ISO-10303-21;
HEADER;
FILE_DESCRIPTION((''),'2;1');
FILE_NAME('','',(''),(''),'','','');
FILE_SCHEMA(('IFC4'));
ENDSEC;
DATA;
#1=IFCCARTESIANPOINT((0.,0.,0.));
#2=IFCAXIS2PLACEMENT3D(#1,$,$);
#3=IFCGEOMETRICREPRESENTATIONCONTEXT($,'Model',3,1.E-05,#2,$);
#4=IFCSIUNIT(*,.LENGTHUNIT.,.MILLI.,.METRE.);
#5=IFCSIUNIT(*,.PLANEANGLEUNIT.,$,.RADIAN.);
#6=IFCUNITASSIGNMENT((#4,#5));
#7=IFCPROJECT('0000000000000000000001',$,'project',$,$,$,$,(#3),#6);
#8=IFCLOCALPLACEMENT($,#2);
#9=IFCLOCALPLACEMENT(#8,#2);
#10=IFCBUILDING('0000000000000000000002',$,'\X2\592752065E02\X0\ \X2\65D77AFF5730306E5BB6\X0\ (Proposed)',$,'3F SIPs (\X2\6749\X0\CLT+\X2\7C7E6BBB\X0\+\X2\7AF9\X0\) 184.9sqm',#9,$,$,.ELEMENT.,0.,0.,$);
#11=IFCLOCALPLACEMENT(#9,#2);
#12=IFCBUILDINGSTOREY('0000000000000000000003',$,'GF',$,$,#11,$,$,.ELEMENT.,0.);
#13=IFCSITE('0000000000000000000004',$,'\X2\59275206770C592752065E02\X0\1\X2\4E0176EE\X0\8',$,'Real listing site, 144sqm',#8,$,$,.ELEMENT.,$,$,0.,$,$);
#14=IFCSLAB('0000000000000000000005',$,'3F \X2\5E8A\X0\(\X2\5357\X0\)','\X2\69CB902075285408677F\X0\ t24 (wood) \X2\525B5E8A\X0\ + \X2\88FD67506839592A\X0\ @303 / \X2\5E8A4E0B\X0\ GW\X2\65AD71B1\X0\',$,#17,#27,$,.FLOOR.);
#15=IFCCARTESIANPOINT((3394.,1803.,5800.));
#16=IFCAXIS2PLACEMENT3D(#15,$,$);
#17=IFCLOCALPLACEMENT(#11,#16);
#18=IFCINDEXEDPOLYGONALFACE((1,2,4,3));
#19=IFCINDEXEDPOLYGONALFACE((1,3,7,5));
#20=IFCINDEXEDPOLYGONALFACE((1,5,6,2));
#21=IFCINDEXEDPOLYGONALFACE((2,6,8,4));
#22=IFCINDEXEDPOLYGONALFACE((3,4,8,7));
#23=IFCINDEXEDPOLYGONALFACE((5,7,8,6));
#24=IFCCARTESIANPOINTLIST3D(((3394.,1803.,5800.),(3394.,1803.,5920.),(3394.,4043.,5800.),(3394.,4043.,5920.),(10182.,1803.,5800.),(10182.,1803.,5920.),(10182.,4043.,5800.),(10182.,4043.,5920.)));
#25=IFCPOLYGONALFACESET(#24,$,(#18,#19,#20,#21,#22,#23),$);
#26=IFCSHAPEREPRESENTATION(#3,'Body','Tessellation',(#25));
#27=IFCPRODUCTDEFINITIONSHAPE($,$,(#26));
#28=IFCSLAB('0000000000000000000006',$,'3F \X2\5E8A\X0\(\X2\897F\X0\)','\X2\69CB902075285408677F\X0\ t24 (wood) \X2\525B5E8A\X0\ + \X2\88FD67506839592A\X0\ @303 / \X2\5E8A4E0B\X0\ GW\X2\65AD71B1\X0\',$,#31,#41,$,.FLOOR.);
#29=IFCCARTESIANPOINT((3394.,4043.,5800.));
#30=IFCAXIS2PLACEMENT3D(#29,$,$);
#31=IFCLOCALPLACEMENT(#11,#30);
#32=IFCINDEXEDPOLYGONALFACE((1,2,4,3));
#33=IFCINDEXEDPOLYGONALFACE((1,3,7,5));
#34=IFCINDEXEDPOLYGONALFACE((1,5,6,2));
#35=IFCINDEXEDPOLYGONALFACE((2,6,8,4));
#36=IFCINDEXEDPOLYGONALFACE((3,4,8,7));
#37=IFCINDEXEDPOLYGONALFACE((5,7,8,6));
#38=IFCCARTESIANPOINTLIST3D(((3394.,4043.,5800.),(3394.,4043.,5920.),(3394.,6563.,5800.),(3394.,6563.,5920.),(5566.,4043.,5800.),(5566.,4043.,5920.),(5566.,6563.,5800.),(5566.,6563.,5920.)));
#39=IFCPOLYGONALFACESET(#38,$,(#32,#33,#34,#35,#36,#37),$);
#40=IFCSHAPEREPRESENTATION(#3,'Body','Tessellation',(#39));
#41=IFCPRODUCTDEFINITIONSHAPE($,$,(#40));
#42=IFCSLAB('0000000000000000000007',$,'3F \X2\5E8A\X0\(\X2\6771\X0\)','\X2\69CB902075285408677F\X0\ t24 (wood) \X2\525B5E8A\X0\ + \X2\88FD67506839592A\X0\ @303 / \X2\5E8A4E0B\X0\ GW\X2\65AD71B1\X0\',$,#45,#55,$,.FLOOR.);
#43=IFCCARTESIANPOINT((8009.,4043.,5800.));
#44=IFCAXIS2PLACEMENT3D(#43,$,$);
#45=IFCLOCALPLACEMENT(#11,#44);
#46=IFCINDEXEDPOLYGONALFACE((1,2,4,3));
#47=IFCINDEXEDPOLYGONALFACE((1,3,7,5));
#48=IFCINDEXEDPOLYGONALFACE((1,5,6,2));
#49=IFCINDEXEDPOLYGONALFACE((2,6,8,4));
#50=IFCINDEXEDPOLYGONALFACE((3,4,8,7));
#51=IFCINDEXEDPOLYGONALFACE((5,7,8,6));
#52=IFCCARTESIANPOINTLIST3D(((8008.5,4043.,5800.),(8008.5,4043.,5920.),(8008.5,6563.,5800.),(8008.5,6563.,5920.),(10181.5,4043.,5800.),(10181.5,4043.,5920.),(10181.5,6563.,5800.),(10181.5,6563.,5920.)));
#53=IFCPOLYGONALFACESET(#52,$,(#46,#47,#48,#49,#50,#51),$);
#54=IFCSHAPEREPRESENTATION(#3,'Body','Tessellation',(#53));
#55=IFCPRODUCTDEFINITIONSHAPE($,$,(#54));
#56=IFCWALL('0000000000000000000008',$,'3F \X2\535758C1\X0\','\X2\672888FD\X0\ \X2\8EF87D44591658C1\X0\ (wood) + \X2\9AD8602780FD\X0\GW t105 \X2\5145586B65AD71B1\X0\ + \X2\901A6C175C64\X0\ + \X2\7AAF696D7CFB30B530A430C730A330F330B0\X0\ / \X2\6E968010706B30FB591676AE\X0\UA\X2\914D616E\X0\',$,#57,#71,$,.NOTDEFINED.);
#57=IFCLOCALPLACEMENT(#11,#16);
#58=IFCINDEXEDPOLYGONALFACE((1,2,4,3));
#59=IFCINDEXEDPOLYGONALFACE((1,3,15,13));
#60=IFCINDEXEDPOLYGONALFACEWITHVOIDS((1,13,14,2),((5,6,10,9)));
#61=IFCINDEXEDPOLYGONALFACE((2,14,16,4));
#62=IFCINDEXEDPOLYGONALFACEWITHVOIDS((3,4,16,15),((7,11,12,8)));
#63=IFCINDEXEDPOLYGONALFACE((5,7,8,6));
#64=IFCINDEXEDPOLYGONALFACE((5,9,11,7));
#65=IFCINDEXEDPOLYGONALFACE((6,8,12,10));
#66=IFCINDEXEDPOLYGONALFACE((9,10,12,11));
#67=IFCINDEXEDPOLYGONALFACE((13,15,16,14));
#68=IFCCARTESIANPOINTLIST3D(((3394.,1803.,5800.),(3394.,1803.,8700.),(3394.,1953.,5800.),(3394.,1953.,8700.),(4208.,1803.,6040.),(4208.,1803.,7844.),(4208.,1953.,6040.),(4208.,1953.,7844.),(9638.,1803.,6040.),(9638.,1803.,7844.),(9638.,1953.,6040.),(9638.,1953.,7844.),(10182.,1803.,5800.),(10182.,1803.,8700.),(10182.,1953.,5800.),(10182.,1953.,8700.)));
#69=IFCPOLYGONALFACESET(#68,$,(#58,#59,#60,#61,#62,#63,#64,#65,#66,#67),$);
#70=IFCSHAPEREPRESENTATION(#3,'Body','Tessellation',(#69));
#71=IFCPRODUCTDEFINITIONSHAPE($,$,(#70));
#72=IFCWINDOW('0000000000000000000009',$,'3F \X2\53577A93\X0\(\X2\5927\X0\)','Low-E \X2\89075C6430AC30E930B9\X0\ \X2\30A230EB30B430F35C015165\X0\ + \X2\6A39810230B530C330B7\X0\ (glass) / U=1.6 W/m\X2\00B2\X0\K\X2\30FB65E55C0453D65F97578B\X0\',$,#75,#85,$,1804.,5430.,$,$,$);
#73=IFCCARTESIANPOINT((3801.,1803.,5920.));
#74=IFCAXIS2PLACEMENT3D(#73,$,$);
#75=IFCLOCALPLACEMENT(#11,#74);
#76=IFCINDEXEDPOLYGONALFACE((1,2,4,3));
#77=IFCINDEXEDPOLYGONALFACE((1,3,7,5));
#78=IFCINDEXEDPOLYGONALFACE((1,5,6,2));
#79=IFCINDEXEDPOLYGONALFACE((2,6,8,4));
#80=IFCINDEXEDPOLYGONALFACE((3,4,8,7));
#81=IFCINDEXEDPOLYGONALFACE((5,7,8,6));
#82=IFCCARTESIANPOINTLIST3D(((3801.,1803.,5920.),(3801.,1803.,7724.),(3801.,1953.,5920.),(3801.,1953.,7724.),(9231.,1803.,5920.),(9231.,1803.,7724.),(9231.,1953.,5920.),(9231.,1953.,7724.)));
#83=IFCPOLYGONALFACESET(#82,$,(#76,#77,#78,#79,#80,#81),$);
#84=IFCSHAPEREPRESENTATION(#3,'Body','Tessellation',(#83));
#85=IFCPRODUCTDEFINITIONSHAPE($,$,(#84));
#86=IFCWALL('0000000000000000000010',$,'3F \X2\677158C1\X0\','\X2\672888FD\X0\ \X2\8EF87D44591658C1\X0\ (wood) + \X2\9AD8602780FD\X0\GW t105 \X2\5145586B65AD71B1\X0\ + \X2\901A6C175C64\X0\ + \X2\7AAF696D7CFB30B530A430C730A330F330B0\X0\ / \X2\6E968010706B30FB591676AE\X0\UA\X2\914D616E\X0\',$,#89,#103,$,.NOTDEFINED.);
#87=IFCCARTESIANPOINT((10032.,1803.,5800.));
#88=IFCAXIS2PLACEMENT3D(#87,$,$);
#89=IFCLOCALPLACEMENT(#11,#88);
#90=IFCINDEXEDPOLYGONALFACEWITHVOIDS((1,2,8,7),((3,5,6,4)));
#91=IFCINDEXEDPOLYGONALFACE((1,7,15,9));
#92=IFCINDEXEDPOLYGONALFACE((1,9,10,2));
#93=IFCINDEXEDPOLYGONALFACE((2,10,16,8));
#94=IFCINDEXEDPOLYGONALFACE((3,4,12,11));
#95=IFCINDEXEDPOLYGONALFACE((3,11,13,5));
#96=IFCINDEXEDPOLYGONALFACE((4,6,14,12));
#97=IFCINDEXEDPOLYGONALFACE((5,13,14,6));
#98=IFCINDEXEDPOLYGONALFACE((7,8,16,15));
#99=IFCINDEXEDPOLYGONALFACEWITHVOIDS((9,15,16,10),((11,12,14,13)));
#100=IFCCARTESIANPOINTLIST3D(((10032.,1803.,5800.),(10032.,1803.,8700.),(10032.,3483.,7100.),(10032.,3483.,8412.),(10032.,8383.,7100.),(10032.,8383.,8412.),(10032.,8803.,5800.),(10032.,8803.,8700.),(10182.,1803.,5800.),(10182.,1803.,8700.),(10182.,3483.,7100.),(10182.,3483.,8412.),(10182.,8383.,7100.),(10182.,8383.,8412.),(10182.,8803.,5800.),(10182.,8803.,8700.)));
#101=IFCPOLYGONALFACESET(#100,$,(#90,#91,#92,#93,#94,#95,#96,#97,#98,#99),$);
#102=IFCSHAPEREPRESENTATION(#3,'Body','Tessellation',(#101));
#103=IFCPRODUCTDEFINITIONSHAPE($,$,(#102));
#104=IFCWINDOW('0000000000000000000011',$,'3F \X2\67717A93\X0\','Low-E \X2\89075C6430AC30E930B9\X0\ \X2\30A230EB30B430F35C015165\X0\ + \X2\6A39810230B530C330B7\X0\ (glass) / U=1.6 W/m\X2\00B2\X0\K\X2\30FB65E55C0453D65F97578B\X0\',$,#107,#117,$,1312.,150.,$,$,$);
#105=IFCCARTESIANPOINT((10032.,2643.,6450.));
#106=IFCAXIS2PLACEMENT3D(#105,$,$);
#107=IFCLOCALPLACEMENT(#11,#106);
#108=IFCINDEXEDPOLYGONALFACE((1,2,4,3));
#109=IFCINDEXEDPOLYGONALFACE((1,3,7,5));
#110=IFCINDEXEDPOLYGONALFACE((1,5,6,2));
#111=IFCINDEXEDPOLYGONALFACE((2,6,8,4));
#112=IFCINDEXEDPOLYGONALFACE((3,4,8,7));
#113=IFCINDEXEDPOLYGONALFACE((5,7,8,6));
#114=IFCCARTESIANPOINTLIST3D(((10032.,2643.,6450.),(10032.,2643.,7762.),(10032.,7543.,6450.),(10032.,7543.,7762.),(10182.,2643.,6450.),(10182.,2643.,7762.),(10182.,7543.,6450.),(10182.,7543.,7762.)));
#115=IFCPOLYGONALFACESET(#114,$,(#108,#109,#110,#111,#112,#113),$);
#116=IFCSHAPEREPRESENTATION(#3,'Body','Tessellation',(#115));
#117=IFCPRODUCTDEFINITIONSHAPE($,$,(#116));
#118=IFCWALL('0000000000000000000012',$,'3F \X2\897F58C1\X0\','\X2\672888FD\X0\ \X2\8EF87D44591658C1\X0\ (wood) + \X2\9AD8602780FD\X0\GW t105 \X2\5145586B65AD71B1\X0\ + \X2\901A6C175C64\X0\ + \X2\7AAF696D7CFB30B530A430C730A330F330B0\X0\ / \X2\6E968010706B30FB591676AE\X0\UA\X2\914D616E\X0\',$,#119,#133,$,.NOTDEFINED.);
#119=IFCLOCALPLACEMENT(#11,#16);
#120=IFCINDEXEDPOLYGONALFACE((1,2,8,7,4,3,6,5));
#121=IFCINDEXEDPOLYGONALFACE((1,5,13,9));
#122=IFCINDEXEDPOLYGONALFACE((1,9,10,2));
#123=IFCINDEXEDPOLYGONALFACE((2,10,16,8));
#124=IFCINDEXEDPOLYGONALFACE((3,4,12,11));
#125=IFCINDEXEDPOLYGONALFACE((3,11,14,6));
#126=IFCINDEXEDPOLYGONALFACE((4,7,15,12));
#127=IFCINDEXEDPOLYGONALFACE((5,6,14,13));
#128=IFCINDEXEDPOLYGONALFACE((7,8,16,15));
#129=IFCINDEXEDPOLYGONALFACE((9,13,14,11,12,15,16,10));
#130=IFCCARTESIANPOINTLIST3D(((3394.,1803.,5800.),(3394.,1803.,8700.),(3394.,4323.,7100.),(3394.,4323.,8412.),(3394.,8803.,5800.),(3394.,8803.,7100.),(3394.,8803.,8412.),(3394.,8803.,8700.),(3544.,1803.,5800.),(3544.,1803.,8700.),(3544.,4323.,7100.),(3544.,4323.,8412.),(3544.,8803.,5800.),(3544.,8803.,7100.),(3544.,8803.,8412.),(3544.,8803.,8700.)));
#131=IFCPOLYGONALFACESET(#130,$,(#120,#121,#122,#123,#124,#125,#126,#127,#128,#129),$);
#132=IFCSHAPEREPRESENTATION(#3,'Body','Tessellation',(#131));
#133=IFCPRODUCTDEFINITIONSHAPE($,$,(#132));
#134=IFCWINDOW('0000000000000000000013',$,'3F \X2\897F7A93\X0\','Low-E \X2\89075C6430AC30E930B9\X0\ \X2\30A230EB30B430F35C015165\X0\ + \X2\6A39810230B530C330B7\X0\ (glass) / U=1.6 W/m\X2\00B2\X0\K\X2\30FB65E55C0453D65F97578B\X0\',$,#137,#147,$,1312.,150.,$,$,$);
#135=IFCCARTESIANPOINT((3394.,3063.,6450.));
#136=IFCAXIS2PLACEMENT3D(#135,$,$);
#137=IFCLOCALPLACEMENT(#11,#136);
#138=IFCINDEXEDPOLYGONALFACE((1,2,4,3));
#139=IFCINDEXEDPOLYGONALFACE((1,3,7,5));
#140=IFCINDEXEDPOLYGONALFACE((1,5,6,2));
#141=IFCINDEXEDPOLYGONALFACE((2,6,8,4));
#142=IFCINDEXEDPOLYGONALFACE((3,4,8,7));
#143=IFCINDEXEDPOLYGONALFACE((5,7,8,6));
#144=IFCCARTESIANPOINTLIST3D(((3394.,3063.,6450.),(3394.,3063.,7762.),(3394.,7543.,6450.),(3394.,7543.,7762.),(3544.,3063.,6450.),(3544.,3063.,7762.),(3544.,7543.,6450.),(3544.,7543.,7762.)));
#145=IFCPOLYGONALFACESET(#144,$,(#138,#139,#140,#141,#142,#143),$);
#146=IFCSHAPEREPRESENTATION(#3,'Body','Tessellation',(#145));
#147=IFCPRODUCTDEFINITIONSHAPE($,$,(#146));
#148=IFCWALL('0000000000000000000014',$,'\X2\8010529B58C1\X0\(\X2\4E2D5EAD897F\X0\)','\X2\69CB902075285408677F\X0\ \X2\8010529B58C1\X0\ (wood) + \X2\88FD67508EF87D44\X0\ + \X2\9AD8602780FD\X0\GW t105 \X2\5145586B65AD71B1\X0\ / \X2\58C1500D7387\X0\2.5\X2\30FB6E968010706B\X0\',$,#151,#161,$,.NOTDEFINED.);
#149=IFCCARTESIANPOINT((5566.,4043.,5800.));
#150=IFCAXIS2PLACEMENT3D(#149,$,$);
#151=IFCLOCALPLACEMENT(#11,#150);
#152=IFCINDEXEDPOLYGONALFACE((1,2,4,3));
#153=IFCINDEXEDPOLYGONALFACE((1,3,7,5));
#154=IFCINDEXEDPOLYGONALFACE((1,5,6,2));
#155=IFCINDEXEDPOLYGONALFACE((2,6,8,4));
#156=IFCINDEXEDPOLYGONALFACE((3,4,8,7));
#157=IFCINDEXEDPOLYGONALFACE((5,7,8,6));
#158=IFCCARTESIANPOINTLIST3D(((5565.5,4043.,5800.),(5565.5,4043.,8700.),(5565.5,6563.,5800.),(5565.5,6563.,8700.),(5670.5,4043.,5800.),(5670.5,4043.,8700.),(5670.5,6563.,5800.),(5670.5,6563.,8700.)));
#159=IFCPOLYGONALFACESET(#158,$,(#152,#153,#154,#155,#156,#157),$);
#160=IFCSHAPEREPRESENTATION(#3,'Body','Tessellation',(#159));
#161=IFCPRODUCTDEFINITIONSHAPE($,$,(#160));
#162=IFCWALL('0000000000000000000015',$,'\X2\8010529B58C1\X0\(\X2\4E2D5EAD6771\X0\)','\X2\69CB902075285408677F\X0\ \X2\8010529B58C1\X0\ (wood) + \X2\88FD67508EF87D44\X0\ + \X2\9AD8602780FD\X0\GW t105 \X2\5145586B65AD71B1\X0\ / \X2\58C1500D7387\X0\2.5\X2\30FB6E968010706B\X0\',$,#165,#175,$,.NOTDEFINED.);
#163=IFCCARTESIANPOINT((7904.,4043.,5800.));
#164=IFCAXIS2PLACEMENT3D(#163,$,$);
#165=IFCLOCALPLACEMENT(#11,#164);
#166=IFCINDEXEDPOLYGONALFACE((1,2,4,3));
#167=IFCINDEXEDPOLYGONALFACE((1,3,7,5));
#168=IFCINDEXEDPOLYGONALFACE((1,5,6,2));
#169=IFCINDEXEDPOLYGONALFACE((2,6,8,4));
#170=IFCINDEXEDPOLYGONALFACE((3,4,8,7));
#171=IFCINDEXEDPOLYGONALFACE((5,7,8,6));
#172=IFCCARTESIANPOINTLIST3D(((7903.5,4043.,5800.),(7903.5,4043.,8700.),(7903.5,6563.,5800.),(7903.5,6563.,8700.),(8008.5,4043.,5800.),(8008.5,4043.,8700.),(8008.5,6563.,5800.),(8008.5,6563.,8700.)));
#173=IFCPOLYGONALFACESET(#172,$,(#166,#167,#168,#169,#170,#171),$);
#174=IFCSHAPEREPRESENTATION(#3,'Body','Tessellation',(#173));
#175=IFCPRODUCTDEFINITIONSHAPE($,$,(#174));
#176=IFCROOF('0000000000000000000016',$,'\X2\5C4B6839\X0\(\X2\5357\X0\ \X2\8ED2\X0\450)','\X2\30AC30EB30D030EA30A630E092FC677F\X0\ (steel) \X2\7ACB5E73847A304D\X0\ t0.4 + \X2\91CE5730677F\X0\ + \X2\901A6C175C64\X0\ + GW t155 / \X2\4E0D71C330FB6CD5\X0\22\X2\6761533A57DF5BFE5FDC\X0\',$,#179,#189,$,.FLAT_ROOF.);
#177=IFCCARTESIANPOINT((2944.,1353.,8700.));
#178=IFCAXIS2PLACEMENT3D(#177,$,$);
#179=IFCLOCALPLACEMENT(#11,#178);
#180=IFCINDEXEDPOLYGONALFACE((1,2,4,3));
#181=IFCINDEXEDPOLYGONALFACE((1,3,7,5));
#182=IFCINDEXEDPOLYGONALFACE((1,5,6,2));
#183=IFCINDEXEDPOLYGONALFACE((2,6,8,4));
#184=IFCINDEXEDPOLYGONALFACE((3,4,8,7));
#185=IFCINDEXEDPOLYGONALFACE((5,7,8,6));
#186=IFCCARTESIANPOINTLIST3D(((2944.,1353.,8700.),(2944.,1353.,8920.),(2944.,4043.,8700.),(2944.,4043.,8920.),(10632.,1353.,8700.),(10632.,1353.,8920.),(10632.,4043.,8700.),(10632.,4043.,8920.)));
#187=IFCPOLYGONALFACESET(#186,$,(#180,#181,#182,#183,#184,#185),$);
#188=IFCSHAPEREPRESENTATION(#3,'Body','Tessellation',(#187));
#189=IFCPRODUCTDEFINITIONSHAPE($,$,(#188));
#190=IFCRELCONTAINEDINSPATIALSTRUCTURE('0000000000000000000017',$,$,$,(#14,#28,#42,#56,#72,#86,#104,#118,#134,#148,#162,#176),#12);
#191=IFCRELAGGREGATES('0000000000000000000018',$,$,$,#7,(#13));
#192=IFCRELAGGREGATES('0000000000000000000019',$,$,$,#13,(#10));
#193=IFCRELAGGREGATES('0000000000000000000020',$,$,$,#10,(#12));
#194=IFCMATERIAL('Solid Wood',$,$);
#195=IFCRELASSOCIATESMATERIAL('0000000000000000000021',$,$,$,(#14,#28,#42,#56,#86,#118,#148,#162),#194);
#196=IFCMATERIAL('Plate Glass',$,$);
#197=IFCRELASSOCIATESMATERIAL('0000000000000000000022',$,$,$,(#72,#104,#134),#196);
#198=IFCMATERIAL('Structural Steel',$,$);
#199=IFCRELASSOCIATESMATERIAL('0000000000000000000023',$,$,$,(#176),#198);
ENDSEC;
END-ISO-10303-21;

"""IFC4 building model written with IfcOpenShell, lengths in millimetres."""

from ifc_helpers import new_model, si_unit, frame, frame_2d, origin, place, context, project, spatial, rectangle, extrude, material, element, fill, save


model = new_model("IFC4")

# Units and contexts
model_context = context("Model", 3, precision=1e-05, world=origin())
ifc_project = project(units=[si_unit("LENGTHUNIT", "METRE", prefix="MILLI"), si_unit("PLANEANGLEUNIT", "RADIAN")], contexts=[model_context])

# Site, building, storey
site_placement = place(None, origin())
site = spatial("IfcSite", under=ifc_project, at=site_placement, Name="大分県大分市1丁目8", ObjectType="Real listing site, 144sqm", CompositionType="ELEMENT", RefElevation=0.0)
building_placement = place(site_placement, origin())
building = spatial("IfcBuilding", under=site, at=building_placement, Name="大分市 旗竿地の家 (Proposed)", ObjectType="3F SIPs (杉CLT+籾殻+竹) 184.9sqm", CompositionType="ELEMENT", ElevationOfRefHeight=0.0, ElevationOfTerrain=0.0)
storey_placement = place(building_placement, origin())
storey = spatial("IfcBuildingStorey", under=building, at=storey_placement, Name="GF", CompositionType="ELEMENT", Elevation=0.0)

# Slabs
ifc_material_1 = material(Name="Solid Wood")
slab_1_placement = place(storey_placement, frame((3394.0, 1803.0, 5800.0)))
element("IfcSlab", 1, at=slab_1_placement, inside=storey, material=ifc_material_1, Name="3F 床(南)", Description="構造用合板 t24 (wood) 剛床 + 製材根太 @303 / 床下 GW断熱", PredefinedType="FLOOR", context=model_context, shape_type="SweptSolid", body=[
    extrude(rectangle(XDim=6788.0, YDim=2240.0, at=frame_2d((3394.0, 1120.0))), frame((3394.0, 1803.0, 5800.0)), (0.0, 0.0, 1.0), 120.0),
])
slab_2_placement = place(storey_placement, frame((3394.0, 4043.0, 5800.0)))
element("IfcSlab", 2, at=slab_2_placement, inside=storey, material=ifc_material_1, Name="3F 床(西)", Description="構造用合板 t24 (wood) 剛床 + 製材根太 @303 / 床下 GW断熱", PredefinedType="FLOOR", context=model_context, shape_type="SweptSolid", body=[
    extrude(rectangle(XDim=2172.0, YDim=2520.0, at=frame_2d((1086.0, 1260.0))), frame((3394.0, 4043.0, 5800.0)), (0.0, 0.0, 1.0), 120.0),
])
slab_3_placement = place(storey_placement, frame((8009.0, 4043.0, 5800.0)))
element("IfcSlab", 3, at=slab_3_placement, inside=storey, material=ifc_material_1, Name="3F 床(東)", Description="構造用合板 t24 (wood) 剛床 + 製材根太 @303 / 床下 GW断熱", PredefinedType="FLOOR", context=model_context, shape_type="SweptSolid", body=[
    extrude(rectangle(XDim=2173.0, YDim=2520.0, at=frame_2d((1086.0, 1260.0))), frame((8009.0, 4043.0, 5800.0)), (0.0, 0.0, 1.0), 120.0),
])

# Walls, openings, windows
wall_1_placement = place(storey_placement, frame((3394.0, 1803.0, 5800.0)))
wall_1 = element("IfcWall", 4, at=wall_1_placement, inside=storey, material=ifc_material_1, Name="3F 南壁", Description="木製 軸組外壁 (wood) + 高性能GW t105 充填断熱 + 通気層 + 窯業系サイディング / 準耐火・外皮UA配慮", PredefinedType="NOTDEFINED", context=model_context, shape_type="SweptSolid", body=[
    extrude(rectangle(XDim=6788.0, YDim=150.0, at=frame_2d((3394.0, 75.0))), frame((3394.0, 1803.0, 5800.0)), (0.0, 0.0, 1.0), 2900.0),
])
opening_1_placement = place(storey_placement, frame((3801.0, 1803.0, 5920.0)))
opening_1 = element("IfcOpeningElement", 5, at=opening_1_placement, cuts=wall_1, PredefinedType="NOTDEFINED", context=model_context, shape_type="SweptSolid", body=[
    extrude(rectangle(XDim=5430.0, YDim=150.0, at=frame_2d((2715.0, 75.0))), frame((3801.0, 1803.0, 5920.0)), (0.0, 0.0, 1.0), 1804.0),
])
ifc_material_2 = material(Name="Plate Glass")
window_1_placement = place(storey_placement, frame((3801.0, 1803.0, 5920.0)))
window_1 = element("IfcWindow", 6, at=window_1_placement, inside=storey, material=ifc_material_2, Name="3F 南窓(大)", Description="Low-E 複層ガラス アルゴン封入 + 樹脂サッシ (glass) / U=1.6 W/m²K・日射取得型", OverallHeight=1804.0, OverallWidth=5430.0, context=model_context, shape_type="SweptSolid", body=[
    extrude(rectangle(XDim=5430.0, YDim=150.0, at=frame_2d((2715.0, 75.0))), frame((3801.0, 1803.0, 5920.0)), (0.0, 0.0, 1.0), 1804.0),
])
fill(opening_1, window_1)
wall_2_placement = place(storey_placement, frame((10032.0, 1803.0, 5800.0)))
wall_2 = element("IfcWall", 7, at=wall_2_placement, inside=storey, material=ifc_material_1, Name="3F 東壁", Description="木製 軸組外壁 (wood) + 高性能GW t105 充填断熱 + 通気層 + 窯業系サイディング / 準耐火・外皮UA配慮", PredefinedType="NOTDEFINED", context=model_context, shape_type="SweptSolid", body=[
    extrude(rectangle(XDim=150.0, YDim=7000.0, at=frame_2d((75.0, 3500.0))), frame((10032.0, 1803.0, 5800.0)), (0.0, 0.0, 1.0), 2900.0),
])
opening_2_placement = place(storey_placement, frame((10032.0, 2643.0, 6450.0)))
opening_2 = element("IfcOpeningElement", 8, at=opening_2_placement, cuts=wall_2, PredefinedType="NOTDEFINED", context=model_context, shape_type="SweptSolid", body=[
    extrude(rectangle(XDim=150.0, YDim=4900.0, at=frame_2d((75.0, 2450.0))), frame((10032.0, 2643.0, 6450.0)), (0.0, 0.0, 1.0), 1312.0),
])
window_2_placement = place(storey_placement, frame((10032.0, 2643.0, 6450.0)))
window_2 = element("IfcWindow", 9, at=window_2_placement, inside=storey, material=ifc_material_2, Name="3F 東窓", Description="Low-E 複層ガラス アルゴン封入 + 樹脂サッシ (glass) / U=1.6 W/m²K・日射取得型", OverallHeight=1312.0, OverallWidth=150.0, context=model_context, shape_type="SweptSolid", body=[
    extrude(rectangle(XDim=150.0, YDim=4900.0, at=frame_2d((75.0, 2450.0))), frame((10032.0, 2643.0, 6450.0)), (0.0, 0.0, 1.0), 1312.0),
])
fill(opening_2, window_2)
wall_3_placement = place(storey_placement, frame((3394.0, 1803.0, 5800.0)))
wall_3 = element("IfcWall", 10, at=wall_3_placement, inside=storey, material=ifc_material_1, Name="3F 西壁", Description="木製 軸組外壁 (wood) + 高性能GW t105 充填断熱 + 通気層 + 窯業系サイディング / 準耐火・外皮UA配慮", PredefinedType="NOTDEFINED", context=model_context, shape_type="SweptSolid", body=[
    extrude(rectangle(XDim=150.0, YDim=7000.0, at=frame_2d((75.0, 3500.0))), frame((3394.0, 1803.0, 5800.0)), (0.0, 0.0, 1.0), 2900.0),
])
opening_3_placement = place(storey_placement, frame((3394.0, 3063.0, 6450.0)))
opening_3 = element("IfcOpeningElement", 11, at=opening_3_placement, cuts=wall_3, PredefinedType="NOTDEFINED", context=model_context, shape_type="SweptSolid", body=[
    extrude(rectangle(XDim=150.0, YDim=4480.0, at=frame_2d((75.0, 2240.0))), frame((3394.0, 3063.0, 6450.0)), (0.0, 0.0, 1.0), 1312.0),
])
window_3_placement = place(storey_placement, frame((3394.0, 3063.0, 6450.0)))
window_3 = element("IfcWindow", 12, at=window_3_placement, inside=storey, material=ifc_material_2, Name="3F 西窓", Description="Low-E 複層ガラス アルゴン封入 + 樹脂サッシ (glass) / U=1.6 W/m²K・日射取得型", OverallHeight=1312.0, OverallWidth=150.0, context=model_context, shape_type="SweptSolid", body=[
    extrude(rectangle(XDim=150.0, YDim=4480.0, at=frame_2d((75.0, 2240.0))), frame((3394.0, 3063.0, 6450.0)), (0.0, 0.0, 1.0), 1312.0),
])
fill(opening_3, window_3)

# Walls
wall_4_placement = place(storey_placement, frame((5566.0, 4043.0, 5800.0)))
element("IfcWall", 13, at=wall_4_placement, inside=storey, material=ifc_material_1, Name="耐力壁(中庭西)", Description="構造用合板 耐力壁 (wood) + 製材軸組 + 高性能GW t105 充填断熱 / 壁倍率2.5・準耐火", PredefinedType="NOTDEFINED", context=model_context, shape_type="SweptSolid", body=[
    extrude(rectangle(XDim=105.0, YDim=2520.0, at=frame_2d((52.0, 1260.0))), frame((5566.0, 4043.0, 5800.0)), (0.0, 0.0, 1.0), 2900.0),
])
wall_5_placement = place(storey_placement, frame((7904.0, 4043.0, 5800.0)))
element("IfcWall", 14, at=wall_5_placement, inside=storey, material=ifc_material_1, Name="耐力壁(中庭東)", Description="構造用合板 耐力壁 (wood) + 製材軸組 + 高性能GW t105 充填断熱 / 壁倍率2.5・準耐火", PredefinedType="NOTDEFINED", context=model_context, shape_type="SweptSolid", body=[
    extrude(rectangle(XDim=105.0, YDim=2520.0, at=frame_2d((52.0, 1260.0))), frame((7904.0, 4043.0, 5800.0)), (0.0, 0.0, 1.0), 2900.0),
])

# Roof
ifc_material_3 = material(Name="Structural Steel")
roof_1_placement = place(storey_placement, frame((2944.0, 1353.0, 8700.0)))
element("IfcRoof", 15, at=roof_1_placement, inside=storey, material=ifc_material_3, Name="屋根(南 軒450)", Description="ガルバリウム鋼板 (steel) 立平葺き t0.4 + 野地板 + 通気層 + GW t155 / 不燃・法22条区域対応", PredefinedType="FLAT_ROOF", context=model_context, shape_type="SweptSolid", body=[
    extrude(rectangle(XDim=7688.0, YDim=2690.0, at=frame_2d((3844.0, 1345.0))), frame((2944.0, 1353.0, 8700.0)), (0.0, 0.0, 1.0), 220.0),
])

save(model, "model.ifc")
